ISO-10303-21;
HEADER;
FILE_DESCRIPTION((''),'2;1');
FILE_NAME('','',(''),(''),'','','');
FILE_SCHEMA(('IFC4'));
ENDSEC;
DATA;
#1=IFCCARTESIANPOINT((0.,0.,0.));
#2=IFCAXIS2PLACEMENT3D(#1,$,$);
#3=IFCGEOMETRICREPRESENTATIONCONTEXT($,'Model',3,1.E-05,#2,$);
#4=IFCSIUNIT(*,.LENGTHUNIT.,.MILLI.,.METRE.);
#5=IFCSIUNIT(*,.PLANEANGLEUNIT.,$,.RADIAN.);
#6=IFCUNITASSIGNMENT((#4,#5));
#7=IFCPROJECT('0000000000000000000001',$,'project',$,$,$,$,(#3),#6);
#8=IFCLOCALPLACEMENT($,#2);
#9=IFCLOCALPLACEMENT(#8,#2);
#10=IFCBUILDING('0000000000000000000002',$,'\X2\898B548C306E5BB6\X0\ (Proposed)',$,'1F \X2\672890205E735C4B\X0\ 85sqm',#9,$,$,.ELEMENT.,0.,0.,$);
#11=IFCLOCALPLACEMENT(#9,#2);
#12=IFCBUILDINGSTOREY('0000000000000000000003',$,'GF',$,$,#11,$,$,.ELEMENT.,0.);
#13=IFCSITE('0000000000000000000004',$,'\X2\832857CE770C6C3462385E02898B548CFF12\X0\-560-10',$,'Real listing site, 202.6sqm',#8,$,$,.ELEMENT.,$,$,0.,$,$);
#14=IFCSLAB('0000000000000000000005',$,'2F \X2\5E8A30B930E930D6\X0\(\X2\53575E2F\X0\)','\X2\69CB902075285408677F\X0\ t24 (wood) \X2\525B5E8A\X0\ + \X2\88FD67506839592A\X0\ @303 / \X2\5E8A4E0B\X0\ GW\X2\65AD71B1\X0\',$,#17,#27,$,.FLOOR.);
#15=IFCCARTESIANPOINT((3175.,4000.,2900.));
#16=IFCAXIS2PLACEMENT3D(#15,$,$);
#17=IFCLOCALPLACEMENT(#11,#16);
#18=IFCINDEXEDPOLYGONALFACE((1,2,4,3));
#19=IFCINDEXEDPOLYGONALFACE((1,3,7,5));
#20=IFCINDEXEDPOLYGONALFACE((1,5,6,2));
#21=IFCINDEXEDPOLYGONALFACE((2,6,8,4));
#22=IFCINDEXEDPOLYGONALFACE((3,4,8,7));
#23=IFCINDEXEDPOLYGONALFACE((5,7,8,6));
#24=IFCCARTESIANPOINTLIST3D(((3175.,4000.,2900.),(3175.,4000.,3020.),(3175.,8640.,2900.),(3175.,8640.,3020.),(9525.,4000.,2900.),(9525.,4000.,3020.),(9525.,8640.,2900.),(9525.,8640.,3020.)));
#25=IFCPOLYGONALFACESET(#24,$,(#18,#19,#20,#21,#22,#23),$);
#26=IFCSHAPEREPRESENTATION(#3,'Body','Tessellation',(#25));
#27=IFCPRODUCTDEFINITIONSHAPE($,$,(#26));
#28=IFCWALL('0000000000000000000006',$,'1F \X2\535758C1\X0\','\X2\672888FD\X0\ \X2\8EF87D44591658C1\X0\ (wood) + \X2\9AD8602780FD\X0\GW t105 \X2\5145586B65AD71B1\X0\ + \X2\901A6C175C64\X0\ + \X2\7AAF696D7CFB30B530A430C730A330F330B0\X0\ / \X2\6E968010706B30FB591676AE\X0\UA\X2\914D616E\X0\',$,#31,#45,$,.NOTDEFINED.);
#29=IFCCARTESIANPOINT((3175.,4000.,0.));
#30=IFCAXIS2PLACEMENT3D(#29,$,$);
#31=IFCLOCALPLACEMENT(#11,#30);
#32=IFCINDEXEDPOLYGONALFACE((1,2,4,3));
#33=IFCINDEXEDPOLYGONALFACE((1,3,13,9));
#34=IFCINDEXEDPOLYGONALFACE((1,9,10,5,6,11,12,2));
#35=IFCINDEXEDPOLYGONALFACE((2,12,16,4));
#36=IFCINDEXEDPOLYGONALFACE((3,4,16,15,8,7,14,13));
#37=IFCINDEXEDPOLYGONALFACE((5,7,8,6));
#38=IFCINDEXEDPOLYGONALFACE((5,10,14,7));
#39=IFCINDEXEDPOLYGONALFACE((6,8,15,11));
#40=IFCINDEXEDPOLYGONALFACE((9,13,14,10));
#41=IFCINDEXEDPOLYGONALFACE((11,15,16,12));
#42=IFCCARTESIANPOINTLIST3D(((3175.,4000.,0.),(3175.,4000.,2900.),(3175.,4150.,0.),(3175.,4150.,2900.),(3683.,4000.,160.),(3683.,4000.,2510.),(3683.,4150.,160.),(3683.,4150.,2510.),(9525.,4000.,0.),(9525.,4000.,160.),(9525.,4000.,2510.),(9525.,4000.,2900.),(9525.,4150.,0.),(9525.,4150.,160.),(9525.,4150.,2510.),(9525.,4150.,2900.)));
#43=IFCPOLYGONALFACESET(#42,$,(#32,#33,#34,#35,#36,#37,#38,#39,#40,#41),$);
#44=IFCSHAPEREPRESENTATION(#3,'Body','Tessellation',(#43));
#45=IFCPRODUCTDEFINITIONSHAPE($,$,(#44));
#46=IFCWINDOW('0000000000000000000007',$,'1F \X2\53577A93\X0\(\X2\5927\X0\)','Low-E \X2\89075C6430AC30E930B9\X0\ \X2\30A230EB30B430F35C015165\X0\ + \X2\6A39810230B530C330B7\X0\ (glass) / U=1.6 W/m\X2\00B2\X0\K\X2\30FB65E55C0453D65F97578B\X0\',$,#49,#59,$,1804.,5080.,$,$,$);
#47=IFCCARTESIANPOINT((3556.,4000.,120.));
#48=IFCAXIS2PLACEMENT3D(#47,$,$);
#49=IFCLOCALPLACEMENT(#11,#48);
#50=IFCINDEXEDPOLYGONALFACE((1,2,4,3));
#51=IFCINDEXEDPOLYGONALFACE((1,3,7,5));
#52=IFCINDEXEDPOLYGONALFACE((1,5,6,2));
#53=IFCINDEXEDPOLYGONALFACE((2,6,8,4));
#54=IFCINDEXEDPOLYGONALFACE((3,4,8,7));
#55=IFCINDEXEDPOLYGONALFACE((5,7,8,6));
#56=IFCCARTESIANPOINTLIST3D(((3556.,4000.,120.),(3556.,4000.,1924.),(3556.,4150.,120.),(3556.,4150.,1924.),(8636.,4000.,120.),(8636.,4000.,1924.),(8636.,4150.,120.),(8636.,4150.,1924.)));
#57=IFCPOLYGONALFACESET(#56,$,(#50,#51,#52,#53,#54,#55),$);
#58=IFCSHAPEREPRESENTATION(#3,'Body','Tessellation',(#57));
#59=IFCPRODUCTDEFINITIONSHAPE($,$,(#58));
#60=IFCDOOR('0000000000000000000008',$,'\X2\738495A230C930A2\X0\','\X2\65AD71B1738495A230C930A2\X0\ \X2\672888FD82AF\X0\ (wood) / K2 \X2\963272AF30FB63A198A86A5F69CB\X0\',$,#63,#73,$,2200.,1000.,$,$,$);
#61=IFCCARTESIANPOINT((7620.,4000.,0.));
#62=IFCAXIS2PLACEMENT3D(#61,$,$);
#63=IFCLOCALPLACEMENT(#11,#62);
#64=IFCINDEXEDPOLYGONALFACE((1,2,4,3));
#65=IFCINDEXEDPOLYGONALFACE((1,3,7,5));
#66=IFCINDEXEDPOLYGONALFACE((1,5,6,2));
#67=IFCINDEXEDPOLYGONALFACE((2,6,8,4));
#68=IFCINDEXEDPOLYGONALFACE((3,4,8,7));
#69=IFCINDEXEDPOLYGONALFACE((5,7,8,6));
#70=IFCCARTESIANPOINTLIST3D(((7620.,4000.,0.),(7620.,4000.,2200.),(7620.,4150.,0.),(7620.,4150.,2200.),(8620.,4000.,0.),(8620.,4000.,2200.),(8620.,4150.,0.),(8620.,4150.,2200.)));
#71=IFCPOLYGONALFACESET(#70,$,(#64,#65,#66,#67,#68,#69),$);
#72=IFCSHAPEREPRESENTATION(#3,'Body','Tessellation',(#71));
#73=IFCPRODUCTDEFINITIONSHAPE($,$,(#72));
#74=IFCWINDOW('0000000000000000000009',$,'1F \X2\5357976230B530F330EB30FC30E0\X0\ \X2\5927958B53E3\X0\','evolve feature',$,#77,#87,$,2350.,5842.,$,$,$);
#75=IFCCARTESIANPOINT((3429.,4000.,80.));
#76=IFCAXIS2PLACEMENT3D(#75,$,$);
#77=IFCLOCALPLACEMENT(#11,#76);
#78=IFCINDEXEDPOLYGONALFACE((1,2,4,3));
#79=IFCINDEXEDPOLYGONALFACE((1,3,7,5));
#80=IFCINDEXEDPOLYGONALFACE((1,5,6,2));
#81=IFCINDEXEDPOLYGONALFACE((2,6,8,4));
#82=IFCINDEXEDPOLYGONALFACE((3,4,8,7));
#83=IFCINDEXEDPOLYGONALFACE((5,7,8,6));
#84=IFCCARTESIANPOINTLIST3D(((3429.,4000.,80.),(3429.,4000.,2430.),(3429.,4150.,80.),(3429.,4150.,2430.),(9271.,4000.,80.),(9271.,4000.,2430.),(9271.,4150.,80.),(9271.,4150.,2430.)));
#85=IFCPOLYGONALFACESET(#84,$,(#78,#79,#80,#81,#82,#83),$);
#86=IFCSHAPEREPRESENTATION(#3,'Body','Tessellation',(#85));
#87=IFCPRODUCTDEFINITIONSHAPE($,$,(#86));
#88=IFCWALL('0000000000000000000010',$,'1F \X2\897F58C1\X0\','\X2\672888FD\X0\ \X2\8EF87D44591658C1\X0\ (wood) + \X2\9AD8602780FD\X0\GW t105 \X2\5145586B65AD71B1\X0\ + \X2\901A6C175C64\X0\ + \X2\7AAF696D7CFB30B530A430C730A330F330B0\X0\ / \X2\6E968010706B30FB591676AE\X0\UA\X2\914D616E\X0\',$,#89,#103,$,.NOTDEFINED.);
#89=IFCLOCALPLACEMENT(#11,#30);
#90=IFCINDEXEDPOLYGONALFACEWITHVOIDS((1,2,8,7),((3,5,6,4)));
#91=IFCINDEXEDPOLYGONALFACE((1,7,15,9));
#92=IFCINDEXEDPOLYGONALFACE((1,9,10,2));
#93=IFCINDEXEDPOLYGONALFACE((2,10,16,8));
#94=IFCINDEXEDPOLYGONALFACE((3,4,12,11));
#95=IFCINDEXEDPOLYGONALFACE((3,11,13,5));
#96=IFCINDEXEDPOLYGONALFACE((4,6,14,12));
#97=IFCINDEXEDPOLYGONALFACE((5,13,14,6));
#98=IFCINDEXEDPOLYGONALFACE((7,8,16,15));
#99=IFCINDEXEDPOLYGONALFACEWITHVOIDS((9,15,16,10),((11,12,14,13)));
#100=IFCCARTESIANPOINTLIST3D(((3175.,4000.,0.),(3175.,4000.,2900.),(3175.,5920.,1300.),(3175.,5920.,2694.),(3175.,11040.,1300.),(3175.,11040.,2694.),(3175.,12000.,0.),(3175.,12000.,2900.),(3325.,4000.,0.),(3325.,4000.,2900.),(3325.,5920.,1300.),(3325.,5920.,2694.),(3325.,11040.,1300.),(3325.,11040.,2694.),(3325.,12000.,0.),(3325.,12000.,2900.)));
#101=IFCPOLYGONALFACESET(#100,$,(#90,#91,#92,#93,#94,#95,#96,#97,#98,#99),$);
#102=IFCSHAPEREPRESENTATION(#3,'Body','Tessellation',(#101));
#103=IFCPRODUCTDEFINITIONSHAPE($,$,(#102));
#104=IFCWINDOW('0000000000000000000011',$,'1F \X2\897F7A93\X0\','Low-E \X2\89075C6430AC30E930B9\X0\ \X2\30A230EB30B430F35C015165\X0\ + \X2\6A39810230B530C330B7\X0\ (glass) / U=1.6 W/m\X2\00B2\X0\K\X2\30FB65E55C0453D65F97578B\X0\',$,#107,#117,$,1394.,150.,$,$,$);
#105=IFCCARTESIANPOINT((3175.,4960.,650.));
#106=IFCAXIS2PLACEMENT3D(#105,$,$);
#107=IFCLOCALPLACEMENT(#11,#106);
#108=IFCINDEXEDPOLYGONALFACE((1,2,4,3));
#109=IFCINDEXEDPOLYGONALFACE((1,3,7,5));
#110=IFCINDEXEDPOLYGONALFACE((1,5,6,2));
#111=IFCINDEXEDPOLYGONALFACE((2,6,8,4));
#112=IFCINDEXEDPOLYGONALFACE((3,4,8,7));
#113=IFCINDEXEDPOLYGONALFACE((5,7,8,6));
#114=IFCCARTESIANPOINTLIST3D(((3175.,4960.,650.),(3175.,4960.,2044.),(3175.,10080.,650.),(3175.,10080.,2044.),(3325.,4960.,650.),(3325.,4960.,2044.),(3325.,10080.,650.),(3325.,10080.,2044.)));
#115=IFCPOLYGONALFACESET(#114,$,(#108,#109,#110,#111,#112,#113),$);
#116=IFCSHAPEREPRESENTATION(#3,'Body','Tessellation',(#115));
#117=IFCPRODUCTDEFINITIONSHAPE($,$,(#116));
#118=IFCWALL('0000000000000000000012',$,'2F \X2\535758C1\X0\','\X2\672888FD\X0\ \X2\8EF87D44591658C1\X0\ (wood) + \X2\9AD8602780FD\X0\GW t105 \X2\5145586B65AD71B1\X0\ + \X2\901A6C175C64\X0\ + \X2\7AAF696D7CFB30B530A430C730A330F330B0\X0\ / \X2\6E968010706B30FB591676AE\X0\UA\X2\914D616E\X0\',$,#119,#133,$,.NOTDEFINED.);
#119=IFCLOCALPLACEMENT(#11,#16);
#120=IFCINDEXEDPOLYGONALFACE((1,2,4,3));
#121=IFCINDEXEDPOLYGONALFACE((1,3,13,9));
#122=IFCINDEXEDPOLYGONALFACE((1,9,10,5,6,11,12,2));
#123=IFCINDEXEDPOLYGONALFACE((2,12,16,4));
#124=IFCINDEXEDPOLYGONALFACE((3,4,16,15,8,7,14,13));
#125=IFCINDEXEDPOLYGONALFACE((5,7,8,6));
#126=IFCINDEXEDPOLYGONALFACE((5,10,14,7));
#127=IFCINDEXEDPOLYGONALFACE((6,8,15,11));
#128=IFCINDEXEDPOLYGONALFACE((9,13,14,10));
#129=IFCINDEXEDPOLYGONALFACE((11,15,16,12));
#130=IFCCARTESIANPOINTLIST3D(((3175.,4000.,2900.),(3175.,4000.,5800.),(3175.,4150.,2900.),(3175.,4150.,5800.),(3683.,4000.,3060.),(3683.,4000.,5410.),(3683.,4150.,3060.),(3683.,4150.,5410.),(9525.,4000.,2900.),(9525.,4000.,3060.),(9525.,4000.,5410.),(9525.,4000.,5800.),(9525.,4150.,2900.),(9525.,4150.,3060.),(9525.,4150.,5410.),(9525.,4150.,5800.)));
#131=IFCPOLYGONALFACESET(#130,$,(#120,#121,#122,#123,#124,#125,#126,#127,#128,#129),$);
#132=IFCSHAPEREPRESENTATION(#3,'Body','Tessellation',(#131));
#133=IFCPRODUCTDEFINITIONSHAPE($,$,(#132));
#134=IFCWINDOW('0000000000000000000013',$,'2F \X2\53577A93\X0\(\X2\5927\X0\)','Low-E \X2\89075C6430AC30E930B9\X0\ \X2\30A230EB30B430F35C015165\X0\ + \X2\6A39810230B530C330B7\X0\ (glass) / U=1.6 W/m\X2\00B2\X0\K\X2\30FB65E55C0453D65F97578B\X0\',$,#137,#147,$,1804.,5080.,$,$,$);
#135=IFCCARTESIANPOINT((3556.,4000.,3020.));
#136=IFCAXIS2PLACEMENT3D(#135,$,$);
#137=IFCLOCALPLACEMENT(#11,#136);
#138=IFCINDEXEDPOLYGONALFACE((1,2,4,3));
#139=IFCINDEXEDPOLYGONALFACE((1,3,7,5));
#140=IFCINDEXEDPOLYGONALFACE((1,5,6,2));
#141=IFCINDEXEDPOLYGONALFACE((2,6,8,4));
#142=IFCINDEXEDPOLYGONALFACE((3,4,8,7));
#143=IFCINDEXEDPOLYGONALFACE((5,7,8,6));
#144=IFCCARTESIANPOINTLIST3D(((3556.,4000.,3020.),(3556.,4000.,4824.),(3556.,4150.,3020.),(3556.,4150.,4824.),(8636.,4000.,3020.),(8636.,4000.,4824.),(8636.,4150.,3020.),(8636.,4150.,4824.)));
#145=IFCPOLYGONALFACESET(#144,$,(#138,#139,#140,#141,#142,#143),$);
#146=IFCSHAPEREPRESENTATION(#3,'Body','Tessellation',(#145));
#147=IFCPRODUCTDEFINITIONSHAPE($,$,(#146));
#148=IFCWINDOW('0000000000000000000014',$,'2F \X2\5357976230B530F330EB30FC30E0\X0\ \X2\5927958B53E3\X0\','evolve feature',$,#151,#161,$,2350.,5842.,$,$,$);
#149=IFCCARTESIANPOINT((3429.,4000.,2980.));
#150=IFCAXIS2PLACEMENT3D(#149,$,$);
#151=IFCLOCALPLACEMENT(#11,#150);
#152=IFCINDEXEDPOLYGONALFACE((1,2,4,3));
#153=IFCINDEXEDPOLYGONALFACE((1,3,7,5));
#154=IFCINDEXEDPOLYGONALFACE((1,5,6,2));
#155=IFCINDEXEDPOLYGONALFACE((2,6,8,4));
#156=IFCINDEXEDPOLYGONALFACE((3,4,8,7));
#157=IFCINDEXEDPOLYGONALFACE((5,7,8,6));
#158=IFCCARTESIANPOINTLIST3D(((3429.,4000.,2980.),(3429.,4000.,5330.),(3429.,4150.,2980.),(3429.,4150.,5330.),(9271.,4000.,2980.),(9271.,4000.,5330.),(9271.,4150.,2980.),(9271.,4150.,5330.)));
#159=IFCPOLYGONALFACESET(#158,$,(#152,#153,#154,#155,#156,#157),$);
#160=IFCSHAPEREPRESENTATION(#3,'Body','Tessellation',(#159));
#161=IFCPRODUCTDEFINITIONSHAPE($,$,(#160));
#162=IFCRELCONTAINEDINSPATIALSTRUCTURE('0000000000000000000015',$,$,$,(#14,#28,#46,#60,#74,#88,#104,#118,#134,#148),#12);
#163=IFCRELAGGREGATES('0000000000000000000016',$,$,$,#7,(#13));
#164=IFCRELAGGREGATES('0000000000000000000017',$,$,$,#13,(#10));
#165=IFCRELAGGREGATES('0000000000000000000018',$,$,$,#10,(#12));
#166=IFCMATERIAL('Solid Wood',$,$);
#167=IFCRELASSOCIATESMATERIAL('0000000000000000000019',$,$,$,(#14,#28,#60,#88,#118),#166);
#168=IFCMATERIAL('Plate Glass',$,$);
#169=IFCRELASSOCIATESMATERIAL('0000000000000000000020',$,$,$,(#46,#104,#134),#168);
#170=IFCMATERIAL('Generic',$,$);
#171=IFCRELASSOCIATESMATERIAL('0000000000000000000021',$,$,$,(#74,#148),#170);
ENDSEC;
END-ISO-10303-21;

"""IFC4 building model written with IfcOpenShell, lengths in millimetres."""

from ifc_helpers import new_model, si_unit, frame, frame_2d, origin, place, context, project, spatial, rectangle, extrude, material, element, fill, save


model = new_model("IFC4")

# Units and contexts
model_context = context("Model", 3, precision=1e-05, world=origin())
ifc_project = project(units=[si_unit("LENGTHUNIT", "METRE", prefix="MILLI"), si_unit("PLANEANGLEUNIT", "RADIAN")], contexts=[model_context])

# Site, building, storey
site_placement = place(None, origin())
site = spatial("IfcSite", under=ifc_project, at=site_placement, Name="茨城県水戸市見和２-560-10", ObjectType="Real listing site, 202.6sqm", CompositionType="ELEMENT", RefElevation=0.0)
building_placement = place(site_placement, origin())
building = spatial("IfcBuilding", under=site, at=building_placement, Name="見和の家 (Proposed)", ObjectType="1F 木造平屋 85sqm", CompositionType="ELEMENT", ElevationOfRefHeight=0.0, ElevationOfTerrain=0.0)
storey_placement = place(building_placement, origin())
storey = spatial("IfcBuildingStorey", under=building, at=storey_placement, Name="GF", CompositionType="ELEMENT", Elevation=0.0)

# Slab
ifc_material_1 = material(Name="Solid Wood")
slab_1_placement = place(storey_placement, frame((3175.0, 4000.0, 2900.0)))
element("IfcSlab", 1, at=slab_1_placement, inside=storey, material=ifc_material_1, Name="2F 床スラブ(南帯)", Description="構造用合板 t24 (wood) 剛床 + 製材根太 @303 / 床下 GW断熱", PredefinedType="FLOOR", context=model_context, shape_type="SweptSolid", body=[
    extrude(rectangle(XDim=6350.0, YDim=4640.0, at=frame_2d((3175.0, 2320.0))), frame((3175.0, 4000.0, 2900.0)), (0.0, 0.0, 1.0), 120.0),
])
ifc_material_2 = material(Name="Generic")

# Wall, openings, windows, door
wall_1_placement = place(storey_placement, frame((3175.0, 4000.0, 0.0)))
wall_1 = element("IfcWall", 2, at=wall_1_placement, inside=storey, material=ifc_material_1, Name="1F 南壁", Description="木製 軸組外壁 (wood) + 高性能GW t105 充填断熱 + 通気層 + 窯業系サイディング / 準耐火・外皮UA配慮", PredefinedType="NOTDEFINED", context=model_context, shape_type="SweptSolid", body=[
    extrude(rectangle(XDim=6350.0, YDim=150.0, at=frame_2d((3175.0, 75.0))), frame((3175.0, 4000.0, 0.0)), (0.0, 0.0, 1.0), 2900.0),
])
opening_1_placement = place(storey_placement, frame((3556.0, 4000.0, 120.0)))
opening_1 = element("IfcOpeningElement", 3, at=opening_1_placement, cuts=wall_1, PredefinedType="NOTDEFINED", context=model_context, shape_type="SweptSolid", body=[
    extrude(rectangle(XDim=5080.0, YDim=150.0, at=frame_2d((2540.0, 75.0))), frame((3556.0, 4000.0, 120.0)), (0.0, 0.0, 1.0), 1804.0),
])
opening_2_placement = place(storey_placement, frame((7620.0, 4000.0, 0.0)))
opening_2 = element("IfcOpeningElement", 4, at=opening_2_placement, cuts=wall_1, PredefinedType="NOTDEFINED", context=model_context, shape_type="SweptSolid", body=[
    extrude(rectangle(XDim=1000.0, YDim=150.0, at=frame_2d((500.0, 75.0))), frame((7620.0, 4000.0, 0.0)), (0.0, 0.0, 1.0), 2200.0),
])
opening_3_placement = place(storey_placement, frame((3429.0, 4000.0, 80.0)))
opening_3 = element("IfcOpeningElement", 5, at=opening_3_placement, cuts=wall_1, PredefinedType="NOTDEFINED", context=model_context, shape_type="SweptSolid", body=[
    extrude(rectangle(XDim=5842.0, YDim=150.0, at=frame_2d((2921.0, 75.0))), frame((3429.0, 4000.0, 80.0)), (0.0, 0.0, 1.0), 2350.0),
])
ifc_material_3 = material(Name="Plate Glass")
window_1_placement = place(storey_placement, frame((3556.0, 4000.0, 120.0)))
window_1 = element("IfcWindow", 6, at=window_1_placement, inside=storey, material=ifc_material_3, Name="1F 南窓(大)", Description="Low-E 複層ガラス アルゴン封入 + 樹脂サッシ (glass) / U=1.6 W/m²K・日射取得型", OverallHeight=1804.0, OverallWidth=5080.0, context=model_context, shape_type="SweptSolid", body=[
    extrude(rectangle(XDim=5080.0, YDim=150.0, at=frame_2d((2540.0, 75.0))), frame((3556.0, 4000.0, 120.0)), (0.0, 0.0, 1.0), 1804.0),
])
fill(opening_1, window_1)
door_placement = place(storey_placement, frame((7620.0, 4000.0, 0.0)))
door = element("IfcDoor", 7, at=door_placement, inside=storey, material=ifc_material_1, Name="玄関ドア", Description="断熱玄関ドア 木製芯 (wood) / K2 防犯・採風機構", OverallHeight=2200.0, OverallWidth=1000.0, context=model_context, shape_type="SweptSolid", body=[
    extrude(rectangle(XDim=1000.0, YDim=150.0, at=frame_2d((500.0, 75.0))), frame((7620.0, 4000.0, 0.0)), (0.0, 0.0, 1.0), 2200.0),
])
fill(opening_2, door)
window_2_placement = place(storey_placement, frame((3429.0, 4000.0, 80.0)))
window_2 = element("IfcWindow", 8, at=window_2_placement, inside=storey, material=ifc_material_2, Name="1F 南面サンルーム 大開口", Description="evolve feature", OverallHeight=2350.0, OverallWidth=5842.0, context=model_context, shape_type="SweptSolid", body=[
    extrude(rectangle(XDim=5842.0, YDim=150.0, at=frame_2d((2921.0, 75.0))), frame((3429.0, 4000.0, 80.0)), (0.0, 0.0, 1.0), 2350.0),
])
fill(opening_3, window_2)

# Wall, opening, window
wall_2_placement = place(storey_placement, frame((3175.0, 4000.0, 0.0)))
wall_2 = element("IfcWall", 9, at=wall_2_placement, inside=storey, material=ifc_material_1, Name="1F 西壁", Description="木製 軸組外壁 (wood) + 高性能GW t105 充填断熱 + 通気層 + 窯業系サイディング / 準耐火・外皮UA配慮", PredefinedType="NOTDEFINED", context=model_context, shape_type="SweptSolid", body=[
    extrude(rectangle(XDim=150.0, YDim=8000.0, at=frame_2d((75.0, 4000.0))), frame((3175.0, 4000.0, 0.0)), (0.0, 0.0, 1.0), 2900.0),
])
opening_4_placement = place(storey_placement, frame((3175.0, 4960.0, 650.0)))
opening_4 = element("IfcOpeningElement", 10, at=opening_4_placement, cuts=wall_2, PredefinedType="NOTDEFINED", context=model_context, shape_type="SweptSolid", body=[
    extrude(rectangle(XDim=150.0, YDim=5120.0, at=frame_2d((75.0, 2560.0))), frame((3175.0, 4960.0, 650.0)), (0.0, 0.0, 1.0), 1394.0),
])
window_3_placement = place(storey_placement, frame((3175.0, 4960.0, 650.0)))
window_3 = element("IfcWindow", 11, at=window_3_placement, inside=storey, material=ifc_material_3, Name="1F 西窓", Description="Low-E 複層ガラス アルゴン封入 + 樹脂サッシ (glass) / U=1.6 W/m²K・日射取得型", OverallHeight=1394.0, OverallWidth=150.0, context=model_context, shape_type="SweptSolid", body=[
    extrude(rectangle(XDim=150.0, YDim=5120.0, at=frame_2d((75.0, 2560.0))), frame((3175.0, 4960.0, 650.0)), (0.0, 0.0, 1.0), 1394.0),
])
fill(opening_4, window_3)

# Wall, openings, windows
wall_3_placement = place(storey_placement, frame((3175.0, 4000.0, 2900.0)))
wall_3 = element("IfcWall", 12, at=wall_3_placement, inside=storey, material=ifc_material_1, Name="2F 南壁", Description="木製 軸組外壁 (wood) + 高性能GW t105 充填断熱 + 通気層 + 窯業系サイディング / 準耐火・外皮UA配慮", PredefinedType="NOTDEFINED", context=model_context, shape_type="SweptSolid", body=[
    extrude(rectangle(XDim=6350.0, YDim=150.0, at=frame_2d((3175.0, 75.0))), frame((3175.0, 4000.0, 2900.0)), (0.0, 0.0, 1.0), 2900.0),
])
opening_5_placement = place(storey_placement, frame((3556.0, 4000.0, 3020.0)))
opening_5 = element("IfcOpeningElement", 13, at=opening_5_placement, cuts=wall_3, PredefinedType="NOTDEFINED", context=model_context, shape_type="SweptSolid", body=[
    extrude(rectangle(XDim=5080.0, YDim=150.0, at=frame_2d((2540.0, 75.0))), frame((3556.0, 4000.0, 3020.0)), (0.0, 0.0, 1.0), 1804.0),
])
opening_6_placement = place(storey_placement, frame((3429.0, 4000.0, 2980.0)))
opening_6 = element("IfcOpeningElement", 14, at=opening_6_placement, cuts=wall_3, PredefinedType="NOTDEFINED", context=model_context, shape_type="SweptSolid", body=[
    extrude(rectangle(XDim=5842.0, YDim=150.0, at=frame_2d((2921.0, 75.0))), frame((3429.0, 4000.0, 2980.0)), (0.0, 0.0, 1.0), 2350.0),
])
window_4_placement = place(storey_placement, frame((3556.0, 4000.0, 3020.0)))
window_4 = element("IfcWindow", 15, at=window_4_placement, inside=storey, material=ifc_material_3, Name="2F 南窓(大)", Description="Low-E 複層ガラス アルゴン封入 + 樹脂サッシ (glass) / U=1.6 W/m²K・日射取得型", OverallHeight=1804.0, OverallWidth=5080.0, context=model_context, shape_type="SweptSolid", body=[
    extrude(rectangle(XDim=5080.0, YDim=150.0, at=frame_2d((2540.0, 75.0))), frame((3556.0, 4000.0, 3020.0)), (0.0, 0.0, 1.0), 1804.0),
])
fill(opening_5, window_4)
window_5_placement = place(storey_placement, frame((3429.0, 4000.0, 2980.0)))
window_5 = element("IfcWindow", 16, at=window_5_placement, inside=storey, material=ifc_material_2, Name="2F 南面サンルーム 大開口", Description="evolve feature", OverallHeight=2350.0, OverallWidth=5842.0, context=model_context, shape_type="SweptSolid", body=[
    extrude(rectangle(XDim=5842.0, YDim=150.0, at=frame_2d((2921.0, 75.0))), frame((3429.0, 4000.0, 2980.0)), (0.0, 0.0, 1.0), 2350.0),
])
fill(opening_6, window_5)

save(model, "model.ifc")
